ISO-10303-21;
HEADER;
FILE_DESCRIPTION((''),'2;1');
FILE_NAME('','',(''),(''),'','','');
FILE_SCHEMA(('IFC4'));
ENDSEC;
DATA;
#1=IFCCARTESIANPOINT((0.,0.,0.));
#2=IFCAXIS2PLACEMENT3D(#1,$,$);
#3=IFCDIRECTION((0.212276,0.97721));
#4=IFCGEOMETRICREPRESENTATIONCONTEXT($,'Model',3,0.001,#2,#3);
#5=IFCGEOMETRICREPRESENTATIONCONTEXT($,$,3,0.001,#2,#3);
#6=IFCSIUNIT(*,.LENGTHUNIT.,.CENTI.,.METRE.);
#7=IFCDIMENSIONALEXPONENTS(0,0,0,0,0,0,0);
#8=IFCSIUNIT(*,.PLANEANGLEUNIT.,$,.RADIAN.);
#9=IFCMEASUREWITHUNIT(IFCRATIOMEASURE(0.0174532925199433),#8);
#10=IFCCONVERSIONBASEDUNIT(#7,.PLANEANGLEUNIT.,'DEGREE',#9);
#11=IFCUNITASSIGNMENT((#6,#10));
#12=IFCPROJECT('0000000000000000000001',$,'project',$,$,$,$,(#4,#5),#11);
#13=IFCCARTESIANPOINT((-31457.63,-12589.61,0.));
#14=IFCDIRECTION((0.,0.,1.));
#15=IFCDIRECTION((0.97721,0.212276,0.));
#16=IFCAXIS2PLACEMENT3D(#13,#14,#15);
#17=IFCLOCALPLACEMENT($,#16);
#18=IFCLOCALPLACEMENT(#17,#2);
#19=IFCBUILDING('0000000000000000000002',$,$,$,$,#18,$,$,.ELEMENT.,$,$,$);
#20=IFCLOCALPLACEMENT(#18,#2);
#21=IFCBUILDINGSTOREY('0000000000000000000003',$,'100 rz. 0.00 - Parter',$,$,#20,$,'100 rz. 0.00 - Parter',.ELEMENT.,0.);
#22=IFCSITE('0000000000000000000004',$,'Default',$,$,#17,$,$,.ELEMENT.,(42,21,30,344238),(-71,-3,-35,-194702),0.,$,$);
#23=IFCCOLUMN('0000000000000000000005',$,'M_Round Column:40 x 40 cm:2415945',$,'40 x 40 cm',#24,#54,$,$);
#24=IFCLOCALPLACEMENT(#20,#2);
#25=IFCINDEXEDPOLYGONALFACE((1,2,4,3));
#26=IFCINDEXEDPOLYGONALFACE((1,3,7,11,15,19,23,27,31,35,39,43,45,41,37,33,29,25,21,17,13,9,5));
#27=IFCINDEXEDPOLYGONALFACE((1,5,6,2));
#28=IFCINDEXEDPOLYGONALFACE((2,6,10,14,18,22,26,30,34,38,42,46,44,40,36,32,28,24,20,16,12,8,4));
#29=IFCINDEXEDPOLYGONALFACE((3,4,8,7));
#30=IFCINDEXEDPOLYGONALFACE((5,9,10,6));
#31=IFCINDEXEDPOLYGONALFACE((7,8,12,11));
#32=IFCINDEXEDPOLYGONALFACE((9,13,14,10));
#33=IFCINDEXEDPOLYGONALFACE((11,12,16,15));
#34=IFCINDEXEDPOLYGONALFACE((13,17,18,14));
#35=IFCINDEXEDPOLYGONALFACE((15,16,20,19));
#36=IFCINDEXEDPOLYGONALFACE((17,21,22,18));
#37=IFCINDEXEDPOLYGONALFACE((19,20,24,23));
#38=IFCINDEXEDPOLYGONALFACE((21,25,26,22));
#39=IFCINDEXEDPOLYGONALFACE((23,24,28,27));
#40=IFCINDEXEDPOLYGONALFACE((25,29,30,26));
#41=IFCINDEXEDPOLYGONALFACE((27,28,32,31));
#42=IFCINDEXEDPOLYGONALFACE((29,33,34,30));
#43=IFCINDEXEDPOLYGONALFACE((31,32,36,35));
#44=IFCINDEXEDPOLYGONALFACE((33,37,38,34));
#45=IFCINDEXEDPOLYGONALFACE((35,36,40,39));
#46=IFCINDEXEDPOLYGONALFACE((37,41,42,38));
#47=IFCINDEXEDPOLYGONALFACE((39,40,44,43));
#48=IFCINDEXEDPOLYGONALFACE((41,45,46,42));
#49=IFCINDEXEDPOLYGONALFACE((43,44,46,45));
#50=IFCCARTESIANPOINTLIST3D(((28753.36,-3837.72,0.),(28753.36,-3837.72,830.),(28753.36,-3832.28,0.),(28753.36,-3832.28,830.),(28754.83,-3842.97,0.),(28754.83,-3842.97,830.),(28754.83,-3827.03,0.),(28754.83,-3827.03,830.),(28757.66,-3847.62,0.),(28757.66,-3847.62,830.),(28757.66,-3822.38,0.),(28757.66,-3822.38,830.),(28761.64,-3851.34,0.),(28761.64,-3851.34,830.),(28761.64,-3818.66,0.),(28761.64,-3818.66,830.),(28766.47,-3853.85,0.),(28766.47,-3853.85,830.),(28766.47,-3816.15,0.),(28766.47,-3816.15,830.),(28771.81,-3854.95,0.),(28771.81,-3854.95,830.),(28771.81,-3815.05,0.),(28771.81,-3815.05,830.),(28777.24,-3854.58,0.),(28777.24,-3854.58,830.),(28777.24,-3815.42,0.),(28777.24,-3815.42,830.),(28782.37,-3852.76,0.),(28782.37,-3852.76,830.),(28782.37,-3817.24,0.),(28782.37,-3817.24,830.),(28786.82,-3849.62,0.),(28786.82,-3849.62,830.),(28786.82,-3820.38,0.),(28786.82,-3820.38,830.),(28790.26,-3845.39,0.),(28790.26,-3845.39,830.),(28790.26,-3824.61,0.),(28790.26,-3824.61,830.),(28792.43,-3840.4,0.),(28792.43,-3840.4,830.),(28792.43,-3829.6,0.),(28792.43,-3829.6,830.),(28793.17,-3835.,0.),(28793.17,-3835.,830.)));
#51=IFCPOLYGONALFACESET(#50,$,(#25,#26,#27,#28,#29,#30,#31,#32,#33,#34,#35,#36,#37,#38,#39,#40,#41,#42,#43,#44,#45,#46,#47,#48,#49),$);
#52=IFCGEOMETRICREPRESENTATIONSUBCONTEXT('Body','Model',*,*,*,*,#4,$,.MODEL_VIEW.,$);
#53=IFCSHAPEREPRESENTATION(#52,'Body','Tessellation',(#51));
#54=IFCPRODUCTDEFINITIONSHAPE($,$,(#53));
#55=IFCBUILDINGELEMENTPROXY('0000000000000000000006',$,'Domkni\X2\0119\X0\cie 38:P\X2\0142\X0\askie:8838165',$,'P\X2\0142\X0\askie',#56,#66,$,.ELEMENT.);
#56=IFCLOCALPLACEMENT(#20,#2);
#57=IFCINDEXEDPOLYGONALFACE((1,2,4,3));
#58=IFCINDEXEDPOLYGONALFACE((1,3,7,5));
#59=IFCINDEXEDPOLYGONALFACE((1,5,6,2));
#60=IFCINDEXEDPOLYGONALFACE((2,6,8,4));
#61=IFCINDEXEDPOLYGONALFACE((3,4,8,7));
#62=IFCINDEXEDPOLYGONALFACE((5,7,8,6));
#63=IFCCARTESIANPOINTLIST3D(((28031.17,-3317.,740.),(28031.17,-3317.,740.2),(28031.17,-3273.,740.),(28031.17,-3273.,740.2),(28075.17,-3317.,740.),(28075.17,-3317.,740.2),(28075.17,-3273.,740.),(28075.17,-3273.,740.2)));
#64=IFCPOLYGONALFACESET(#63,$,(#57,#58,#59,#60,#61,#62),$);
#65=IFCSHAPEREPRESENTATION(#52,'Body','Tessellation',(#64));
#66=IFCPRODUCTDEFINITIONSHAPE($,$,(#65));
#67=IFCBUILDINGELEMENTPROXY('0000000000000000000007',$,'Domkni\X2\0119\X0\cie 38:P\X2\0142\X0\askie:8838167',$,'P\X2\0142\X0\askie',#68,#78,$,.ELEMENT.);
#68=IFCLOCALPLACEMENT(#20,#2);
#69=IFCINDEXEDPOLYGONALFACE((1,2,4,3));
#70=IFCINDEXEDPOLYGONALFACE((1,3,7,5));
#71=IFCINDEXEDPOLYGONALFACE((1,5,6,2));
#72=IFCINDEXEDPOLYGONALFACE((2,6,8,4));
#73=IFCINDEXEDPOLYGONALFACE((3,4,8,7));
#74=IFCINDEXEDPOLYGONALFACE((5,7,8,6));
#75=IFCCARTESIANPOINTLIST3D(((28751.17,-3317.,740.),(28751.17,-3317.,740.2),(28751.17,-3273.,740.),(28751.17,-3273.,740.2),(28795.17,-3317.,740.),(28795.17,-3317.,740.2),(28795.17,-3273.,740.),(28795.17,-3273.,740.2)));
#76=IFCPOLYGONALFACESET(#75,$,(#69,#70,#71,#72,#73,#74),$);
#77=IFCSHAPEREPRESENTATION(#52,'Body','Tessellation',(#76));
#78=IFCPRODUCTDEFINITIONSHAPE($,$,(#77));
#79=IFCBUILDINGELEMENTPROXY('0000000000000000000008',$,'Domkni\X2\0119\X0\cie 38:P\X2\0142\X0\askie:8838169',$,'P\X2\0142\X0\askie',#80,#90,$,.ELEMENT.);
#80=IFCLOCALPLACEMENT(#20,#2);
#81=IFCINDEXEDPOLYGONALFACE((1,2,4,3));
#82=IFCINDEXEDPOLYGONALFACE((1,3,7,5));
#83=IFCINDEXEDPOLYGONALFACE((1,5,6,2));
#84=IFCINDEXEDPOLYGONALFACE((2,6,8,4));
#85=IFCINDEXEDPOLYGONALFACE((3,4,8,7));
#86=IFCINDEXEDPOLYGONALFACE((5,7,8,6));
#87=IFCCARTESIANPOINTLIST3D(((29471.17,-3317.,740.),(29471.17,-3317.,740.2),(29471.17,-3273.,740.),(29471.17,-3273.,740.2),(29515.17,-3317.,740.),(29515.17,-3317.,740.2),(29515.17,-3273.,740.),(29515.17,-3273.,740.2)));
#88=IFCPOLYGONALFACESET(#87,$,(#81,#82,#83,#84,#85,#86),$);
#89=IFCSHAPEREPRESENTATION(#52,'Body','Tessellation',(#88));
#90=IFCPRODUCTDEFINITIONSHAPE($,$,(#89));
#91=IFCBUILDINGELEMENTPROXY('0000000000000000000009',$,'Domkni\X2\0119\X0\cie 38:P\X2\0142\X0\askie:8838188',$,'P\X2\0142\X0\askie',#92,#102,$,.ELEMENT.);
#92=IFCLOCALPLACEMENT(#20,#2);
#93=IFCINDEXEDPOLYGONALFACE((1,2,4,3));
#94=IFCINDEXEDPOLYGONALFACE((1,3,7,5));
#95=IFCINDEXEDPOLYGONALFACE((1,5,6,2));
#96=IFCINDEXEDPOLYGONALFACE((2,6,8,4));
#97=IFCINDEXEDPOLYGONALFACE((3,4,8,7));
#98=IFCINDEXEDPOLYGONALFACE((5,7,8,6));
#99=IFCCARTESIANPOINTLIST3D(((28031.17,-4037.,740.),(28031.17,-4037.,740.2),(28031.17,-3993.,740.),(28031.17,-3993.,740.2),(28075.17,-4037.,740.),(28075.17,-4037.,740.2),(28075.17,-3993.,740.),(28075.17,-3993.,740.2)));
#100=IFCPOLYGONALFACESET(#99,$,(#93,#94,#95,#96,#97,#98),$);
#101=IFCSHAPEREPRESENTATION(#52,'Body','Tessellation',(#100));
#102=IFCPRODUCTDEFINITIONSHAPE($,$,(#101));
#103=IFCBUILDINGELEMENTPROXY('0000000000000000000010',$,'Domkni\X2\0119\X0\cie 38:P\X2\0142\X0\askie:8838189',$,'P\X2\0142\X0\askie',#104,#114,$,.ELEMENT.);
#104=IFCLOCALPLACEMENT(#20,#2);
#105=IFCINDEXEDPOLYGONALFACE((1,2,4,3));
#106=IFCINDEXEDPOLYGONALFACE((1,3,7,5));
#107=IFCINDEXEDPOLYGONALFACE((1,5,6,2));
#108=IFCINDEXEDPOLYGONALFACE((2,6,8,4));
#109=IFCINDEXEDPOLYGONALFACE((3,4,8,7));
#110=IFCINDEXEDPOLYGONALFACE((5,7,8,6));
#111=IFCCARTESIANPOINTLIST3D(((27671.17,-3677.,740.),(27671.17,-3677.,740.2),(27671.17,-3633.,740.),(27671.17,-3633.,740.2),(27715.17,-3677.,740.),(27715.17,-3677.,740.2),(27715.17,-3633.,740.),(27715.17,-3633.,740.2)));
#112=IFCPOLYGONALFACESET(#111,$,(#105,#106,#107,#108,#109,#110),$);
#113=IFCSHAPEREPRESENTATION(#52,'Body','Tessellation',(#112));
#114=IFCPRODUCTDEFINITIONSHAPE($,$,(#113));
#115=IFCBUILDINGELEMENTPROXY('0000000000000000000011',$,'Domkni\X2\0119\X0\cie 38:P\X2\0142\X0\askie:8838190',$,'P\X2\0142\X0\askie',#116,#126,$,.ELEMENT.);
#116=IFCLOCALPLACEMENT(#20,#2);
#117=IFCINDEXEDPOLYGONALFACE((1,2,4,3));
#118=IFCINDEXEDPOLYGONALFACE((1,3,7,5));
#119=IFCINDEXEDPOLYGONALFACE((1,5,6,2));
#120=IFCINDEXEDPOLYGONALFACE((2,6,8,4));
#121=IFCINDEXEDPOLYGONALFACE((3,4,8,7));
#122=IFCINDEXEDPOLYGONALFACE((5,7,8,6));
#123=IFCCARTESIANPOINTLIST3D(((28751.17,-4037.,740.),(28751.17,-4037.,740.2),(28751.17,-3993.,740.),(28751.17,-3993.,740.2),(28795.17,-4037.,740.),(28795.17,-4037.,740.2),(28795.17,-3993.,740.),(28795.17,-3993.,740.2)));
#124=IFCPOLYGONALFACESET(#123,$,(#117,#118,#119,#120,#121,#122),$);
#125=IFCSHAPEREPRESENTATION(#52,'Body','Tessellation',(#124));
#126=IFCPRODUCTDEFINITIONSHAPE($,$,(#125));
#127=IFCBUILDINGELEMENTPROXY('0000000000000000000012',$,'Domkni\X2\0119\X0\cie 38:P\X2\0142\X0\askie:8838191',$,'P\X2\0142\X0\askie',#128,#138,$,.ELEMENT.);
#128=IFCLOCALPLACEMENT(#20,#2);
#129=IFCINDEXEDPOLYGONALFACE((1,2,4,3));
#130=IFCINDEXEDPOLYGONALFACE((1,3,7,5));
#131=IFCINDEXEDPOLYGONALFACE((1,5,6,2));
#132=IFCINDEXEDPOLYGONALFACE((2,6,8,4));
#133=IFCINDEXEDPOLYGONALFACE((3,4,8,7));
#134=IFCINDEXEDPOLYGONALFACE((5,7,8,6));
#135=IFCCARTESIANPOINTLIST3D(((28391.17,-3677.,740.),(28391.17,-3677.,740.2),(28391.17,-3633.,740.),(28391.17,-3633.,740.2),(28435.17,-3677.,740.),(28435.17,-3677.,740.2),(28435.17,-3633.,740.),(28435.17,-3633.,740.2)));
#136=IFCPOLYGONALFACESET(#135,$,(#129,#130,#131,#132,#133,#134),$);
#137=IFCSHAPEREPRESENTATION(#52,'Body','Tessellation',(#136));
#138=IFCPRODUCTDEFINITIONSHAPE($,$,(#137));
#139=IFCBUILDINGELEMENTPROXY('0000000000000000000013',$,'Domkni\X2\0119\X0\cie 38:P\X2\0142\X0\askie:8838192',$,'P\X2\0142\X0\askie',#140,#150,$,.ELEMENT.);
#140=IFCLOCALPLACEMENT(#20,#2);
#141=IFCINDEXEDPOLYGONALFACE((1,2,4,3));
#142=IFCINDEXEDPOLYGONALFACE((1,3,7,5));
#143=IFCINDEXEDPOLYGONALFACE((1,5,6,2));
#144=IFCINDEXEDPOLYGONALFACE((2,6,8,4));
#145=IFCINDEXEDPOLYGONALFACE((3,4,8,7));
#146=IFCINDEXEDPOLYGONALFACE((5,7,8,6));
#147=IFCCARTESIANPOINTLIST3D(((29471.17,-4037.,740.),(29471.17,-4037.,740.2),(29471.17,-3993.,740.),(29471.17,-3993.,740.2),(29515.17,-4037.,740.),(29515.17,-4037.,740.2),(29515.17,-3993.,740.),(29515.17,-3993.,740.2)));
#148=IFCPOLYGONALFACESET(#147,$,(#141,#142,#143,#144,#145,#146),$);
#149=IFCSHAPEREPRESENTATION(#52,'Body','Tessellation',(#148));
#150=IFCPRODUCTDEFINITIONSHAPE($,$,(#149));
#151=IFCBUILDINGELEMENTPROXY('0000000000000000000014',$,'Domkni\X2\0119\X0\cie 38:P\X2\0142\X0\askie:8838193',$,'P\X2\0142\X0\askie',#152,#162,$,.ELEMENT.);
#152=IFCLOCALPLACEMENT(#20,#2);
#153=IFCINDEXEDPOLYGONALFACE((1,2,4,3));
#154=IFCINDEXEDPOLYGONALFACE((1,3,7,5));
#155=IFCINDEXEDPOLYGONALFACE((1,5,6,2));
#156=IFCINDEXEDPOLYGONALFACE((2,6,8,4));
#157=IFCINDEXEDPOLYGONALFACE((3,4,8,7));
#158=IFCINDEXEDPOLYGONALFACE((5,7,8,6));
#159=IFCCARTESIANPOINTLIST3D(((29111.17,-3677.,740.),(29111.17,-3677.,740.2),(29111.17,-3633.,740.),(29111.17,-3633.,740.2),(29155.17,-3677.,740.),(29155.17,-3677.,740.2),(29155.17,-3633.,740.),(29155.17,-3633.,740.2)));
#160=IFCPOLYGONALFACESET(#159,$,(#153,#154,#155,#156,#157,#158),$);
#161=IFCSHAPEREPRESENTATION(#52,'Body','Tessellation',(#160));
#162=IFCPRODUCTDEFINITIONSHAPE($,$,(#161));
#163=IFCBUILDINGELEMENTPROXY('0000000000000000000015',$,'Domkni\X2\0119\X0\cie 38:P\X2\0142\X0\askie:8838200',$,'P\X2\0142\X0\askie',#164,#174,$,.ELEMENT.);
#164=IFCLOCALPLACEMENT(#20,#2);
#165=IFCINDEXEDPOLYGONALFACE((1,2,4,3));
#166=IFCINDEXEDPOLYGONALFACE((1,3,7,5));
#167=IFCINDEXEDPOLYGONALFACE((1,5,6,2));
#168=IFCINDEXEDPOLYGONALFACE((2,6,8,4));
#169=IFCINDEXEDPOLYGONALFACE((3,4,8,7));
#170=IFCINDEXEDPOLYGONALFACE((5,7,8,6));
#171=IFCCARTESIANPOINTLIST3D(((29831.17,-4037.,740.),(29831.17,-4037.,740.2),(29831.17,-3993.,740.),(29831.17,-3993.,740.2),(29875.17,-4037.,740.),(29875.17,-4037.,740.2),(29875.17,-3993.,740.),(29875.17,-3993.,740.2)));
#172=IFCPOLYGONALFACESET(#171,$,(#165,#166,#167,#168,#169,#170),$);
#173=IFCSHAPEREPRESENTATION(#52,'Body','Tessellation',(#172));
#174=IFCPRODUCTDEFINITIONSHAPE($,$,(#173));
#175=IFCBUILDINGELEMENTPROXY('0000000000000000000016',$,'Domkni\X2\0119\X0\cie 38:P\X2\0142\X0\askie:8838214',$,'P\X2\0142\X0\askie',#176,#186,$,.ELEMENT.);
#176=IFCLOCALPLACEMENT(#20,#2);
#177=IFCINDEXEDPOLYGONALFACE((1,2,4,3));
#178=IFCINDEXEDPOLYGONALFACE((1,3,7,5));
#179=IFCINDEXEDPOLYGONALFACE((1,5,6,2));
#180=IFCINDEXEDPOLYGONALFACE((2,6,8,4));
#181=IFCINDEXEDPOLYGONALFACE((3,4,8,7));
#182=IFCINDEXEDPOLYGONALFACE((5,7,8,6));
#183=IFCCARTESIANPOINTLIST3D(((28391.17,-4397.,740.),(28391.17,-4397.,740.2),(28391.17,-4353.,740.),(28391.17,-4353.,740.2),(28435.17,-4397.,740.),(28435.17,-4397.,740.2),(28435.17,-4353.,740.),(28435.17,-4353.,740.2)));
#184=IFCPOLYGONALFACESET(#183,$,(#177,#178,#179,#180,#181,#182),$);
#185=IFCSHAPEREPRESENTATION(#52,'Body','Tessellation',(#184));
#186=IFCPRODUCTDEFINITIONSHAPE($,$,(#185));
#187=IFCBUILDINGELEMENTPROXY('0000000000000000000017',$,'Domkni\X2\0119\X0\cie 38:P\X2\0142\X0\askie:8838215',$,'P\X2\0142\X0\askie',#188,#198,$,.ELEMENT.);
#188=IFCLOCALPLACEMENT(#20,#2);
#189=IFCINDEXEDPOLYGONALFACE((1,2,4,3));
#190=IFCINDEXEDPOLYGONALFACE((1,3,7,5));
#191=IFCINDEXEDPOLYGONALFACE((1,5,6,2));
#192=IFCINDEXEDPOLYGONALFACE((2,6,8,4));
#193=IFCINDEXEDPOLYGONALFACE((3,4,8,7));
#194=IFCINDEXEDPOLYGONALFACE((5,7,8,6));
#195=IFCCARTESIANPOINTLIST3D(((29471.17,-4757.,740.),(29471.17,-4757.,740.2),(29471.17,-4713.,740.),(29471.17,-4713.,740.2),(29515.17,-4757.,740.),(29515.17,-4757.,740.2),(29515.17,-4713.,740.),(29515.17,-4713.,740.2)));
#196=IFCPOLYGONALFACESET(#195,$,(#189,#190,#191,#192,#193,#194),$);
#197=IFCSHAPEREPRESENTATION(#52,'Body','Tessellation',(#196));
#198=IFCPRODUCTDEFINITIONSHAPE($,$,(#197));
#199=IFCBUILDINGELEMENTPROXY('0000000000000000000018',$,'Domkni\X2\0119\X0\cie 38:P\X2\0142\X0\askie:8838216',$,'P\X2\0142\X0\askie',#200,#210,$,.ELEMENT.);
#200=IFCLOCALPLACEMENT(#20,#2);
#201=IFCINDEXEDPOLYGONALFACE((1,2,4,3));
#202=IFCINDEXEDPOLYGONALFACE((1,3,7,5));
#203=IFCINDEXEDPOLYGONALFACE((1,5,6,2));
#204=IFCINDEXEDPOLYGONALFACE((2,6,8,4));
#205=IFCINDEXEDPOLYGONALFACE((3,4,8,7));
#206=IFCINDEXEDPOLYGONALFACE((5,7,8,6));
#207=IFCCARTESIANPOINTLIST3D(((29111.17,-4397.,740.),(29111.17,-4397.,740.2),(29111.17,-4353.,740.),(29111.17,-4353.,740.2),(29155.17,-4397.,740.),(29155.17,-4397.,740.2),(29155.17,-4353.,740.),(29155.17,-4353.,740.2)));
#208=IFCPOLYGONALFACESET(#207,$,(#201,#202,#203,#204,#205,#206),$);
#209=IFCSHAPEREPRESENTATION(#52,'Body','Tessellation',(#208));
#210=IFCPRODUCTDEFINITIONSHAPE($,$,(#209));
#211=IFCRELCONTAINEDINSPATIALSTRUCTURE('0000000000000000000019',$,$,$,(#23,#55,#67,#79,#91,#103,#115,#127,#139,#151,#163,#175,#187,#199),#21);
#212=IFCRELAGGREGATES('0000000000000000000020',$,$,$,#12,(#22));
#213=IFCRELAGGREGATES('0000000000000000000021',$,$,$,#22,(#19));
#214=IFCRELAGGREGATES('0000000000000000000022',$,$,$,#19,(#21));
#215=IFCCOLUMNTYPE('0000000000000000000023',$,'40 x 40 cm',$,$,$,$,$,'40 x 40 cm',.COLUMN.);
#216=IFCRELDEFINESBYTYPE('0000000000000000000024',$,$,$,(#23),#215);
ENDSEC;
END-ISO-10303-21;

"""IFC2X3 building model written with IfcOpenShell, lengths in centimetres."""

from ifc_helpers import new_model, entity, si_unit, converted_unit, direction, frame, frame_2d, origin, origin_2d_with_axis, place, context, subcontext, project, spatial, rectangle, circle, extrude, source, transform, mapped, type_object, type_shapes, element, save


model = new_model("IFC2X3")

# Units and contexts
model_context = context("Model", 3, precision=0.001, world=origin(), true_north=direction((0.212276, 0.97721)))
context_of_model = context(None, 3, precision=0.001, world=origin(), true_north=direction((0.212276, 0.97721)))
body_context = subcontext(model_context, "Body", "Model", "MODEL_VIEW")
ifc_project = project(units=[si_unit("LENGTHUNIT", "METRE", prefix="CENTI"), converted_unit("PLANEANGLEUNIT", "DEGREE", entity("IfcRatioMeasure", 0.0174532925199433), si_unit("PLANEANGLEUNIT", "RADIAN"), dimensions=[0, 0, 0, 0, 0, 0, 0])], contexts=[model_context, context_of_model])

# Site, building, storey
site_placement = place(None, frame((-31457.63, -12589.61, 0.0), z_axis=(0.0, 0.0, 1.0), x_axis=(0.97721, 0.212276, 0.0)))
site = spatial("IfcSite", under=ifc_project, at=site_placement, Name="Default", CompositionType="ELEMENT", RefLatitude=(42, 21, 30, 344238), RefLongitude=(-71, -3, -35, -194702), RefElevation=0.0)
building_placement = place(site_placement, origin())
building = spatial("IfcBuilding", under=site, at=building_placement, CompositionType="ELEMENT")
storey_placement = place(building_placement, origin())
storey = spatial("IfcBuildingStorey", under=building, at=storey_placement, Name="100 rz. 0.00 - Parter", LongName="100 rz. 0.00 - Parter", CompositionType="ELEMENT", Elevation=0.0)

# Column
column_type = type_object("IfcColumnType", Name="40 x 40 cm", ElementType="40 x 40 cm", PredefinedType="COLUMN")
shared_shape_1 = source(origin(), body_context, "Body", "SweptSolid", [
    extrude(circle(Radius=20.0, at=frame_2d((0.0, 0.0), x_axis=(1.0, 0.0))), origin(), (0.0, 0.0, 1.0), 830.0),
])
type_shapes(column_type, [shared_shape_1])
column_placement = place(storey_placement, frame((28773.17, -3835.0, 0.0)))
element("IfcColumn", 1, at=column_placement, inside=storey, type_object=column_type, Name="M_Round Column:40 x 40 cm:2415945", ObjectType="40 x 40 cm", context=body_context, shape_type="MappedRepresentation", body=[
    mapped(shared_shape_1, transform((0.0, 0.0, 0.0), scale=1.0)),
])

# Building element proxies
shared_shape_2 = source(origin(), body_context, "Body", "SweptSolid", [
    extrude(rectangle(XDim=44.0, YDim=44.0, at=origin_2d_with_axis()), frame((22.0, 22.0, 0.0), z_axis=(0.0, 0.0, 1.0), x_axis=(-1.0, 0.0, 0.0)), (0.0, 0.0, 1.0), 0.2),
])
for number, where, name in (
    (2, (28031.17, -3317.0, 740.0), "Domknięcie 38:Płaskie:8838165"),
    (3, (28751.17, -3317.0, 740.0), "Domknięcie 38:Płaskie:8838167"),
    (4, (29471.17, -3317.0, 740.0), "Domknięcie 38:Płaskie:8838169"),
    (5, (28031.17, -4037.0, 740.0), "Domknięcie 38:Płaskie:8838188"),
    (6, (27671.17, -3677.0, 740.0), "Domknięcie 38:Płaskie:8838189"),
    (7, (28751.17, -4037.0, 740.0), "Domknięcie 38:Płaskie:8838190"),
    (8, (28391.17, -3677.0, 740.0), "Domknięcie 38:Płaskie:8838191"),
    (9, (29471.17, -4037.0, 740.0), "Domknięcie 38:Płaskie:8838192"),
    (10, (29111.17, -3677.0, 740.0), "Domknięcie 38:Płaskie:8838193"),
    (11, (29831.17, -4037.0, 740.0), "Domknięcie 38:Płaskie:8838200"),
    (12, (28391.17, -4397.0, 740.0), "Domknięcie 38:Płaskie:8838214"),
    (13, (29471.17, -4757.0, 740.0), "Domknięcie 38:Płaskie:8838215"),
    (14, (29111.17, -4397.0, 740.0), "Domknięcie 38:Płaskie:8838216"),
):
    element("IfcBuildingElementProxy", number, at=place(storey_placement, frame(where)), inside=storey, Name=name, ObjectType="Płaskie", CompositionType="ELEMENT", context=body_context, shape_type="MappedRepresentation", body=[
        mapped(shared_shape_2, transform((0.0, 0.0, 0.0), scale=1.0)),
    ])

save(model, "model.ifc")
